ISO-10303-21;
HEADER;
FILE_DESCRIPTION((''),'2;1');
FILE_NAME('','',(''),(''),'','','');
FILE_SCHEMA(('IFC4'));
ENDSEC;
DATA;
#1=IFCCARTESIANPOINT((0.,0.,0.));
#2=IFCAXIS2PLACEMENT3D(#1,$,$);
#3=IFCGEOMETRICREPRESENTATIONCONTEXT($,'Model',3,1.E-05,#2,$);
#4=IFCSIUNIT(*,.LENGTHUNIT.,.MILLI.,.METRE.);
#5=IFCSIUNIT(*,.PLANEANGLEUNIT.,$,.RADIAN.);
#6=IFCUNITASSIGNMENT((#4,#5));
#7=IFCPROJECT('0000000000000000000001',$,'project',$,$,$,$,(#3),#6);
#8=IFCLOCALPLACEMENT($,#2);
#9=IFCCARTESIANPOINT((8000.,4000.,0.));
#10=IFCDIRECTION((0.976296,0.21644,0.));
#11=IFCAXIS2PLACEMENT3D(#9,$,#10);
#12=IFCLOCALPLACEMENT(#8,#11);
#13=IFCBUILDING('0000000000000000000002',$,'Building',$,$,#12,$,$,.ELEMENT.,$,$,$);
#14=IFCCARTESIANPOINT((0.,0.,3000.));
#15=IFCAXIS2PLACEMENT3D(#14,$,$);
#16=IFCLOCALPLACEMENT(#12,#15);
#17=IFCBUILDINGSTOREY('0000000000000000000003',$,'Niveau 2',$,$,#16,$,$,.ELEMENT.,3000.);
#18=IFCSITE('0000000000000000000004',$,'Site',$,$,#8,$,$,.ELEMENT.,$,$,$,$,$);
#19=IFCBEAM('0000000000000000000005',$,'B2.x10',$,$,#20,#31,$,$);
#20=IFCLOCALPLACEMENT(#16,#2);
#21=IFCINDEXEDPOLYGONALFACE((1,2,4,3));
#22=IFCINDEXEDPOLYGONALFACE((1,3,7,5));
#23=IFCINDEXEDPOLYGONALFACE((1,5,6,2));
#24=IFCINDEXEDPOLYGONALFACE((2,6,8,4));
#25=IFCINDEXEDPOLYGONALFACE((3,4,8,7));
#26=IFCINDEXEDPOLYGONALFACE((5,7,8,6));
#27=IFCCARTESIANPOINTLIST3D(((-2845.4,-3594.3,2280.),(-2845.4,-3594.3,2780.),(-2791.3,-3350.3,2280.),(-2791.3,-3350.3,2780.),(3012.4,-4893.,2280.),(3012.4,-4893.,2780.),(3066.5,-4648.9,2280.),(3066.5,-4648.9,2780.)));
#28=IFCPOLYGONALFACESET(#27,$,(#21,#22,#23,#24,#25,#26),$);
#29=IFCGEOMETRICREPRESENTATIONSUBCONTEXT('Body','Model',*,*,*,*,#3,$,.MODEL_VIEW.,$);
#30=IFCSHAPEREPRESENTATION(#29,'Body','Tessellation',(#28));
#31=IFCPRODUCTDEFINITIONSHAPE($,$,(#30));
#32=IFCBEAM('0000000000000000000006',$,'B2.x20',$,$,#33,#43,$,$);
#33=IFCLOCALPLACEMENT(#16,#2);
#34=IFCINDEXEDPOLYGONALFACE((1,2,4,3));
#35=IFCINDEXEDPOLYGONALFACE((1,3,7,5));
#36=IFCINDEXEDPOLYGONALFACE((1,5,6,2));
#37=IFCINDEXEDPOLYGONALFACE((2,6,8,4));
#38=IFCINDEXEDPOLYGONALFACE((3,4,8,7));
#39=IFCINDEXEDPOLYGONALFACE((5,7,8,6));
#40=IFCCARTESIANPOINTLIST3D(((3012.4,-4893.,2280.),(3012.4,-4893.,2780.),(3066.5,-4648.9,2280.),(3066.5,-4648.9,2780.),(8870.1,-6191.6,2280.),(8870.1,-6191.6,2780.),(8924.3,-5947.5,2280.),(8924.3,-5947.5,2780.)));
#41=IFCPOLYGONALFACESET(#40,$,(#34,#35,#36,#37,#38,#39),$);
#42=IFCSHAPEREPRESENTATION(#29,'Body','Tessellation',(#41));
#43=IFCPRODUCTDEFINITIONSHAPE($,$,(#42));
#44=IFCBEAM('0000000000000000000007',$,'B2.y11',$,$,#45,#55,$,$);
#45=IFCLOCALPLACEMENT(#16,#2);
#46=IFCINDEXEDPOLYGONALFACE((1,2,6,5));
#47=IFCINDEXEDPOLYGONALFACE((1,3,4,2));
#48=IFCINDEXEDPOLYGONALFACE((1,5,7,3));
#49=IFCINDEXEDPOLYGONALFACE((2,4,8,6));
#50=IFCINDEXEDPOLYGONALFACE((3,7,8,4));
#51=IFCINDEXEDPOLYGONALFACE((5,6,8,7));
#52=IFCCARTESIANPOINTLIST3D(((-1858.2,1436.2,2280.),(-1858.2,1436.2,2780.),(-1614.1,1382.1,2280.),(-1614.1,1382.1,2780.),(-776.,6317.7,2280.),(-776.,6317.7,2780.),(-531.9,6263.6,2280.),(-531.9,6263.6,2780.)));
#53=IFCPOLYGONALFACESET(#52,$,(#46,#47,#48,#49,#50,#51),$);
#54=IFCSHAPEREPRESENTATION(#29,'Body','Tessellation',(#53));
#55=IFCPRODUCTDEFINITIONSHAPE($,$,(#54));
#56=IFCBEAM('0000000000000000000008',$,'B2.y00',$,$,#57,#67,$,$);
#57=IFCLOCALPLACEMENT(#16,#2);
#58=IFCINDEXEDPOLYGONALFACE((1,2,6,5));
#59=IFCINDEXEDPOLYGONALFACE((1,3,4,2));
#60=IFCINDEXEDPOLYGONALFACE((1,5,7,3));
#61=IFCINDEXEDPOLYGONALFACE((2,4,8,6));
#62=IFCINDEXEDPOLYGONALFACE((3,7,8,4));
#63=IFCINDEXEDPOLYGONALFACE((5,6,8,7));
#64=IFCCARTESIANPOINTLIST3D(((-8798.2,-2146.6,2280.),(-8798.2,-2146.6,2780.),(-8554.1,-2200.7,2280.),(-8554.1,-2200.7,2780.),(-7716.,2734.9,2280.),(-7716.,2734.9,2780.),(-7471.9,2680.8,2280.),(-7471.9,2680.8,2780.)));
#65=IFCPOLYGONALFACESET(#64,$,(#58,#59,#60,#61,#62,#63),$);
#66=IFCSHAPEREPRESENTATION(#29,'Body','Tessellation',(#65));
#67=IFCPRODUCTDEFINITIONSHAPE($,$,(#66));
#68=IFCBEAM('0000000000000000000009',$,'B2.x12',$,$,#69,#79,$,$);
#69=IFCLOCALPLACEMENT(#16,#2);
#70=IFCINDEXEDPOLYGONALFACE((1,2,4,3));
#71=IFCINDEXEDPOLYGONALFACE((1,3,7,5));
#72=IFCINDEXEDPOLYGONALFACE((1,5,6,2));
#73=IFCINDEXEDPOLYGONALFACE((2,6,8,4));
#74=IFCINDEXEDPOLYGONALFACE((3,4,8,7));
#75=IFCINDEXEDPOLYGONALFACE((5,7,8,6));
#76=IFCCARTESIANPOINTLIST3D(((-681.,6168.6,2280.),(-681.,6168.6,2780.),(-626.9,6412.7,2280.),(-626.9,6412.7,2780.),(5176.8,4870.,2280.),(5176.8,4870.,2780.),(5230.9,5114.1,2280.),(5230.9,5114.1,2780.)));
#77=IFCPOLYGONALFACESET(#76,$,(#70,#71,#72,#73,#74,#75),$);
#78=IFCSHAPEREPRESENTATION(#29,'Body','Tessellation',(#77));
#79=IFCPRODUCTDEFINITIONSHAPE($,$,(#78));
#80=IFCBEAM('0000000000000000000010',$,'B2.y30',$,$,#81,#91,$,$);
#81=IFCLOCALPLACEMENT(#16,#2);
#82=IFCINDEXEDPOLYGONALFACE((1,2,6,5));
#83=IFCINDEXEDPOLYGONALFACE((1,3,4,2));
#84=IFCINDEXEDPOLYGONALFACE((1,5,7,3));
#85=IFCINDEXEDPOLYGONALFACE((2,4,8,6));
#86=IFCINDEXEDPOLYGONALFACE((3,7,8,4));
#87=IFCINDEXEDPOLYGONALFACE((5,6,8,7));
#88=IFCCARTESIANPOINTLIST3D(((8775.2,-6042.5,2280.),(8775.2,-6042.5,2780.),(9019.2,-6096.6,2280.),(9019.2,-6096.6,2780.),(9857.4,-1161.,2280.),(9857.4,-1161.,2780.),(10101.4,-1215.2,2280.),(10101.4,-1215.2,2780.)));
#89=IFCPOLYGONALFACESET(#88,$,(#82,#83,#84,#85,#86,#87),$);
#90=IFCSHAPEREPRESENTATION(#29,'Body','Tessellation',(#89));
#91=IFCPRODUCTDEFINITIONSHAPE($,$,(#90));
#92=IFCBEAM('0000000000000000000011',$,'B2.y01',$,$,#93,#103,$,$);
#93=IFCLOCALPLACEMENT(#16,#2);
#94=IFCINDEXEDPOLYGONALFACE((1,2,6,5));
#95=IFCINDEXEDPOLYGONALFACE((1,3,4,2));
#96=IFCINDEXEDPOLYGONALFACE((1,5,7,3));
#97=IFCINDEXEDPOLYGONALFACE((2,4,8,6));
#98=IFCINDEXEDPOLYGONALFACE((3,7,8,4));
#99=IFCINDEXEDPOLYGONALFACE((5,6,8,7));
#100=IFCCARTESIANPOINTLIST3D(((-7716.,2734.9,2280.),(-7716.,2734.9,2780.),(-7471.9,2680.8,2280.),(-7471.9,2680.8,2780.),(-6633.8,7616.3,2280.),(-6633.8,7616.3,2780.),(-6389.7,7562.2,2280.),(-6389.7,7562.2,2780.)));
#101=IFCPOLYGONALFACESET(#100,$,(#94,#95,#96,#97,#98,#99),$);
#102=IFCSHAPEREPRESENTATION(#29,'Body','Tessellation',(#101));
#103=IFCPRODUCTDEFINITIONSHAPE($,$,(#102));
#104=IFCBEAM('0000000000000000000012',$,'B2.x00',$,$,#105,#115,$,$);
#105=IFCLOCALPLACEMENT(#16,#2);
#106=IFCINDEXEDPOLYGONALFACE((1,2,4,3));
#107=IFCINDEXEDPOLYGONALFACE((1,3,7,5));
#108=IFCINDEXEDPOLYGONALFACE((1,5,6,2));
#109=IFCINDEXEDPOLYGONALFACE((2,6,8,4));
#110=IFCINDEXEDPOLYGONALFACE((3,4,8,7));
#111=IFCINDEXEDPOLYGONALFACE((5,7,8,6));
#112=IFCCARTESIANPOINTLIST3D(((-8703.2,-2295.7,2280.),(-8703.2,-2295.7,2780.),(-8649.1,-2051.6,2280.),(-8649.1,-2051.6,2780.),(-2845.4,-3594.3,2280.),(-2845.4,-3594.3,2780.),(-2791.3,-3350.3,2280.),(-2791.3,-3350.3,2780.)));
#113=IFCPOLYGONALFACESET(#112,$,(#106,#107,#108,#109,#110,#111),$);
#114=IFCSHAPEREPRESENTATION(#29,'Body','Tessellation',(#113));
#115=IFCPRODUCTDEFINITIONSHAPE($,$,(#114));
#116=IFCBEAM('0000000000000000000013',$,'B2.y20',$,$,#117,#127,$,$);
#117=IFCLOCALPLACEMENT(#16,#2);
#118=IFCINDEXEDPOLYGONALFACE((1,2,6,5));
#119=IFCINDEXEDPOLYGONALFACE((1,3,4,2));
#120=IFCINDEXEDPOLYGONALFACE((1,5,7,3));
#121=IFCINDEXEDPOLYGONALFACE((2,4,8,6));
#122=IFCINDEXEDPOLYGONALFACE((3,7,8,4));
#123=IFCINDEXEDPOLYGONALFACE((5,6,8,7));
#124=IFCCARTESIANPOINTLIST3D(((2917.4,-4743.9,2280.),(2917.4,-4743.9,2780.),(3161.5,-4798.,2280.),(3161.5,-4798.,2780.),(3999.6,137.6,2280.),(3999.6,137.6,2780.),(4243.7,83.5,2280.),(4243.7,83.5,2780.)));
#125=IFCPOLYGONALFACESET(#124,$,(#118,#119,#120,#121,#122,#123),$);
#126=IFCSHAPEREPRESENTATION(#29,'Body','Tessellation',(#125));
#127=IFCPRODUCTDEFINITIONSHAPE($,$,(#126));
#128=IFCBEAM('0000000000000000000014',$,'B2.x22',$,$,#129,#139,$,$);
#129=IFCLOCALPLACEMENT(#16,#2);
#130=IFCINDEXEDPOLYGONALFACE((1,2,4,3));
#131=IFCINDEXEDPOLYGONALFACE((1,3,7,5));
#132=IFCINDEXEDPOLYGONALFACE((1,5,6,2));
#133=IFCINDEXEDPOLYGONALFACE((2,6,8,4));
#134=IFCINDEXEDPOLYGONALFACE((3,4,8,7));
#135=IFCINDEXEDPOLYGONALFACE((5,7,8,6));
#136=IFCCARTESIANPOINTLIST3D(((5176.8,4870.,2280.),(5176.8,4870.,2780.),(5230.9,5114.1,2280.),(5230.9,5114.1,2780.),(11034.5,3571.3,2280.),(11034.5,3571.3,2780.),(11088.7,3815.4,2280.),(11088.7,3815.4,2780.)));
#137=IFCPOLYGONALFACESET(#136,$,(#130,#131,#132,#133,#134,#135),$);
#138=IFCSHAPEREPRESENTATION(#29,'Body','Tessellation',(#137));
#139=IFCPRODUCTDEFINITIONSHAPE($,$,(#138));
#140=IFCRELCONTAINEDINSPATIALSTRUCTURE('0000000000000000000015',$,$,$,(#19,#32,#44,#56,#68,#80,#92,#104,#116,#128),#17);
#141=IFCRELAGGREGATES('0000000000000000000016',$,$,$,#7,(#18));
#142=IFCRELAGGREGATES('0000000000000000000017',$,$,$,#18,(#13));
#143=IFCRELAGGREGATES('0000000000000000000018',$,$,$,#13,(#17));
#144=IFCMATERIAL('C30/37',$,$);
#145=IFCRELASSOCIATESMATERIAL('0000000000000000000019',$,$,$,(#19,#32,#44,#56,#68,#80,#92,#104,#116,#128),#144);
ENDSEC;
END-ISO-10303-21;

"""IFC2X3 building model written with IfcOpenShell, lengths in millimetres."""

from ifc_helpers import new_model, si_unit, frame, origin, origin_2d, place, context, subcontext, project, spatial, rectangle, extrude, material, element, save


model = new_model("IFC2X3")

# Units and contexts
model_context = context("Model", 3, precision=1e-05, world=origin())
body_context = subcontext(model_context, "Body", "Model", "MODEL_VIEW")
ifc_project = project(units=[si_unit("LENGTHUNIT", "METRE", prefix="MILLI"), si_unit("PLANEANGLEUNIT", "RADIAN")], contexts=[model_context])

# Site, building, storey
site_placement = place(None, origin())
site = spatial("IfcSite", under=ifc_project, at=site_placement, Name="Site", CompositionType="ELEMENT")
building_placement = place(site_placement, frame((8000.0, 4000.0, 0.0), x_axis=(0.976296, 0.21644, 0.0)))
building = spatial("IfcBuilding", under=site, at=building_placement, Name="Building", CompositionType="ELEMENT")
storey_placement = place(building_placement, frame((0.0, 0.0, 3000.0)))
storey = spatial("IfcBuildingStorey", under=building, at=storey_placement, Name="Niveau 2", CompositionType="ELEMENT", Elevation=3000.0)

# Shared definitions
ifc_material = material(Name="C30/37")

# Beams
for number, where, z_axis, x_axis, name in (
    (1, (-2818.4, -3472.3, 2530.0), (0.976296, -0.21644, 0.0), (0.21644, 0.976296, 0.0), "B2.x10"),
    (2, (3039.4, -4770.9, 2530.0), (0.976296, -0.21644, 0.0), (0.21644, 0.976296, 0.0), "B2.x20"),
):
    element("IfcBeam", number, at=place(storey_placement, frame(where, z_axis=z_axis, x_axis=x_axis)), inside=storey, material=ifc_material, Name=name, context=body_context, shape_type="SweptSolid", body=[
        extrude(rectangle(XDim=250.0, YDim=500.0, at=origin_2d()), origin(), (0.0, 0.0, 1.0), 6000.0),
    ])
for number, where, z_axis, x_axis, name in (
    (3, (-1736.2, 1409.2, 2530.0), (0.21644, 0.976296, 0.0), (-0.976296, 0.21644, 0.0), "B2.y11"),
    (4, (-8676.1, -2173.7, 2530.0), (0.21644, 0.976296, 0.0), (-0.976296, 0.21644, 0.0), "B2.y00"),
):
    element("IfcBeam", number, at=place(storey_placement, frame(where, z_axis=z_axis, x_axis=x_axis)), inside=storey, material=ifc_material, Name=name, context=body_context, shape_type="SweptSolid", body=[
        extrude(rectangle(XDim=250.0, YDim=500.0, at=origin_2d()), origin(), (0.0, 0.0, 1.0), 5000.0),
    ])
beam_1_placement = place(storey_placement, frame((-654.0, 6290.7, 2530.0), z_axis=(0.976296, -0.21644, 0.0), x_axis=(0.21644, 0.976296, 0.0)))
element("IfcBeam", 5, at=beam_1_placement, inside=storey, material=ifc_material, Name="B2.x12", context=body_context, shape_type="SweptSolid", body=[
    extrude(rectangle(XDim=250.0, YDim=500.0, at=origin_2d()), origin(), (0.0, 0.0, 1.0), 6000.0),
])
for number, where, z_axis, x_axis, name in (
    (6, (8897.2, -6069.6, 2530.0), (0.21644, 0.976296, 0.0), (-0.976296, 0.21644, 0.0), "B2.y30"),
    (7, (-7593.9, 2707.8, 2530.0), (0.21644, 0.976296, 0.0), (-0.976296, 0.21644, 0.0), "B2.y01"),
):
    element("IfcBeam", number, at=place(storey_placement, frame(where, z_axis=z_axis, x_axis=x_axis)), inside=storey, material=ifc_material, Name=name, context=body_context, shape_type="SweptSolid", body=[
        extrude(rectangle(XDim=250.0, YDim=500.0, at=origin_2d()), origin(), (0.0, 0.0, 1.0), 5000.0),
    ])
beam_2_placement = place(storey_placement, frame((-8676.1, -2173.7, 2530.0), z_axis=(0.976296, -0.21644, 0.0), x_axis=(0.21644, 0.976296, 0.0)))
element("IfcBeam", 8, at=beam_2_placement, inside=storey, material=ifc_material, Name="B2.x00", context=body_context, shape_type="SweptSolid", body=[
    extrude(rectangle(XDim=250.0, YDim=500.0, at=origin_2d()), origin(), (0.0, 0.0, 1.0), 6000.0),
])
beam_3_placement = place(storey_placement, frame((3039.4, -4770.9, 2530.0), z_axis=(0.21644, 0.976296, 0.0), x_axis=(-0.976296, 0.21644, 0.0)))
element("IfcBeam", 9, at=beam_3_placement, inside=storey, material=ifc_material, Name="B2.y20", context=body_context, shape_type="SweptSolid", body=[
    extrude(rectangle(XDim=250.0, YDim=500.0, at=origin_2d()), origin(), (0.0, 0.0, 1.0), 5000.0),
])
beam_4_placement = place(storey_placement, frame((5203.8, 4992.0, 2530.0), z_axis=(0.976296, -0.21644, 0.0), x_axis=(0.21644, 0.976296, 0.0)))
element("IfcBeam", 10, at=beam_4_placement, inside=storey, material=ifc_material, Name="B2.x22", context=body_context, shape_type="SweptSolid", body=[
    extrude(rectangle(XDim=250.0, YDim=500.0, at=origin_2d()), origin(), (0.0, 0.0, 1.0), 6000.0),
])

save(model, "model.ifc")
